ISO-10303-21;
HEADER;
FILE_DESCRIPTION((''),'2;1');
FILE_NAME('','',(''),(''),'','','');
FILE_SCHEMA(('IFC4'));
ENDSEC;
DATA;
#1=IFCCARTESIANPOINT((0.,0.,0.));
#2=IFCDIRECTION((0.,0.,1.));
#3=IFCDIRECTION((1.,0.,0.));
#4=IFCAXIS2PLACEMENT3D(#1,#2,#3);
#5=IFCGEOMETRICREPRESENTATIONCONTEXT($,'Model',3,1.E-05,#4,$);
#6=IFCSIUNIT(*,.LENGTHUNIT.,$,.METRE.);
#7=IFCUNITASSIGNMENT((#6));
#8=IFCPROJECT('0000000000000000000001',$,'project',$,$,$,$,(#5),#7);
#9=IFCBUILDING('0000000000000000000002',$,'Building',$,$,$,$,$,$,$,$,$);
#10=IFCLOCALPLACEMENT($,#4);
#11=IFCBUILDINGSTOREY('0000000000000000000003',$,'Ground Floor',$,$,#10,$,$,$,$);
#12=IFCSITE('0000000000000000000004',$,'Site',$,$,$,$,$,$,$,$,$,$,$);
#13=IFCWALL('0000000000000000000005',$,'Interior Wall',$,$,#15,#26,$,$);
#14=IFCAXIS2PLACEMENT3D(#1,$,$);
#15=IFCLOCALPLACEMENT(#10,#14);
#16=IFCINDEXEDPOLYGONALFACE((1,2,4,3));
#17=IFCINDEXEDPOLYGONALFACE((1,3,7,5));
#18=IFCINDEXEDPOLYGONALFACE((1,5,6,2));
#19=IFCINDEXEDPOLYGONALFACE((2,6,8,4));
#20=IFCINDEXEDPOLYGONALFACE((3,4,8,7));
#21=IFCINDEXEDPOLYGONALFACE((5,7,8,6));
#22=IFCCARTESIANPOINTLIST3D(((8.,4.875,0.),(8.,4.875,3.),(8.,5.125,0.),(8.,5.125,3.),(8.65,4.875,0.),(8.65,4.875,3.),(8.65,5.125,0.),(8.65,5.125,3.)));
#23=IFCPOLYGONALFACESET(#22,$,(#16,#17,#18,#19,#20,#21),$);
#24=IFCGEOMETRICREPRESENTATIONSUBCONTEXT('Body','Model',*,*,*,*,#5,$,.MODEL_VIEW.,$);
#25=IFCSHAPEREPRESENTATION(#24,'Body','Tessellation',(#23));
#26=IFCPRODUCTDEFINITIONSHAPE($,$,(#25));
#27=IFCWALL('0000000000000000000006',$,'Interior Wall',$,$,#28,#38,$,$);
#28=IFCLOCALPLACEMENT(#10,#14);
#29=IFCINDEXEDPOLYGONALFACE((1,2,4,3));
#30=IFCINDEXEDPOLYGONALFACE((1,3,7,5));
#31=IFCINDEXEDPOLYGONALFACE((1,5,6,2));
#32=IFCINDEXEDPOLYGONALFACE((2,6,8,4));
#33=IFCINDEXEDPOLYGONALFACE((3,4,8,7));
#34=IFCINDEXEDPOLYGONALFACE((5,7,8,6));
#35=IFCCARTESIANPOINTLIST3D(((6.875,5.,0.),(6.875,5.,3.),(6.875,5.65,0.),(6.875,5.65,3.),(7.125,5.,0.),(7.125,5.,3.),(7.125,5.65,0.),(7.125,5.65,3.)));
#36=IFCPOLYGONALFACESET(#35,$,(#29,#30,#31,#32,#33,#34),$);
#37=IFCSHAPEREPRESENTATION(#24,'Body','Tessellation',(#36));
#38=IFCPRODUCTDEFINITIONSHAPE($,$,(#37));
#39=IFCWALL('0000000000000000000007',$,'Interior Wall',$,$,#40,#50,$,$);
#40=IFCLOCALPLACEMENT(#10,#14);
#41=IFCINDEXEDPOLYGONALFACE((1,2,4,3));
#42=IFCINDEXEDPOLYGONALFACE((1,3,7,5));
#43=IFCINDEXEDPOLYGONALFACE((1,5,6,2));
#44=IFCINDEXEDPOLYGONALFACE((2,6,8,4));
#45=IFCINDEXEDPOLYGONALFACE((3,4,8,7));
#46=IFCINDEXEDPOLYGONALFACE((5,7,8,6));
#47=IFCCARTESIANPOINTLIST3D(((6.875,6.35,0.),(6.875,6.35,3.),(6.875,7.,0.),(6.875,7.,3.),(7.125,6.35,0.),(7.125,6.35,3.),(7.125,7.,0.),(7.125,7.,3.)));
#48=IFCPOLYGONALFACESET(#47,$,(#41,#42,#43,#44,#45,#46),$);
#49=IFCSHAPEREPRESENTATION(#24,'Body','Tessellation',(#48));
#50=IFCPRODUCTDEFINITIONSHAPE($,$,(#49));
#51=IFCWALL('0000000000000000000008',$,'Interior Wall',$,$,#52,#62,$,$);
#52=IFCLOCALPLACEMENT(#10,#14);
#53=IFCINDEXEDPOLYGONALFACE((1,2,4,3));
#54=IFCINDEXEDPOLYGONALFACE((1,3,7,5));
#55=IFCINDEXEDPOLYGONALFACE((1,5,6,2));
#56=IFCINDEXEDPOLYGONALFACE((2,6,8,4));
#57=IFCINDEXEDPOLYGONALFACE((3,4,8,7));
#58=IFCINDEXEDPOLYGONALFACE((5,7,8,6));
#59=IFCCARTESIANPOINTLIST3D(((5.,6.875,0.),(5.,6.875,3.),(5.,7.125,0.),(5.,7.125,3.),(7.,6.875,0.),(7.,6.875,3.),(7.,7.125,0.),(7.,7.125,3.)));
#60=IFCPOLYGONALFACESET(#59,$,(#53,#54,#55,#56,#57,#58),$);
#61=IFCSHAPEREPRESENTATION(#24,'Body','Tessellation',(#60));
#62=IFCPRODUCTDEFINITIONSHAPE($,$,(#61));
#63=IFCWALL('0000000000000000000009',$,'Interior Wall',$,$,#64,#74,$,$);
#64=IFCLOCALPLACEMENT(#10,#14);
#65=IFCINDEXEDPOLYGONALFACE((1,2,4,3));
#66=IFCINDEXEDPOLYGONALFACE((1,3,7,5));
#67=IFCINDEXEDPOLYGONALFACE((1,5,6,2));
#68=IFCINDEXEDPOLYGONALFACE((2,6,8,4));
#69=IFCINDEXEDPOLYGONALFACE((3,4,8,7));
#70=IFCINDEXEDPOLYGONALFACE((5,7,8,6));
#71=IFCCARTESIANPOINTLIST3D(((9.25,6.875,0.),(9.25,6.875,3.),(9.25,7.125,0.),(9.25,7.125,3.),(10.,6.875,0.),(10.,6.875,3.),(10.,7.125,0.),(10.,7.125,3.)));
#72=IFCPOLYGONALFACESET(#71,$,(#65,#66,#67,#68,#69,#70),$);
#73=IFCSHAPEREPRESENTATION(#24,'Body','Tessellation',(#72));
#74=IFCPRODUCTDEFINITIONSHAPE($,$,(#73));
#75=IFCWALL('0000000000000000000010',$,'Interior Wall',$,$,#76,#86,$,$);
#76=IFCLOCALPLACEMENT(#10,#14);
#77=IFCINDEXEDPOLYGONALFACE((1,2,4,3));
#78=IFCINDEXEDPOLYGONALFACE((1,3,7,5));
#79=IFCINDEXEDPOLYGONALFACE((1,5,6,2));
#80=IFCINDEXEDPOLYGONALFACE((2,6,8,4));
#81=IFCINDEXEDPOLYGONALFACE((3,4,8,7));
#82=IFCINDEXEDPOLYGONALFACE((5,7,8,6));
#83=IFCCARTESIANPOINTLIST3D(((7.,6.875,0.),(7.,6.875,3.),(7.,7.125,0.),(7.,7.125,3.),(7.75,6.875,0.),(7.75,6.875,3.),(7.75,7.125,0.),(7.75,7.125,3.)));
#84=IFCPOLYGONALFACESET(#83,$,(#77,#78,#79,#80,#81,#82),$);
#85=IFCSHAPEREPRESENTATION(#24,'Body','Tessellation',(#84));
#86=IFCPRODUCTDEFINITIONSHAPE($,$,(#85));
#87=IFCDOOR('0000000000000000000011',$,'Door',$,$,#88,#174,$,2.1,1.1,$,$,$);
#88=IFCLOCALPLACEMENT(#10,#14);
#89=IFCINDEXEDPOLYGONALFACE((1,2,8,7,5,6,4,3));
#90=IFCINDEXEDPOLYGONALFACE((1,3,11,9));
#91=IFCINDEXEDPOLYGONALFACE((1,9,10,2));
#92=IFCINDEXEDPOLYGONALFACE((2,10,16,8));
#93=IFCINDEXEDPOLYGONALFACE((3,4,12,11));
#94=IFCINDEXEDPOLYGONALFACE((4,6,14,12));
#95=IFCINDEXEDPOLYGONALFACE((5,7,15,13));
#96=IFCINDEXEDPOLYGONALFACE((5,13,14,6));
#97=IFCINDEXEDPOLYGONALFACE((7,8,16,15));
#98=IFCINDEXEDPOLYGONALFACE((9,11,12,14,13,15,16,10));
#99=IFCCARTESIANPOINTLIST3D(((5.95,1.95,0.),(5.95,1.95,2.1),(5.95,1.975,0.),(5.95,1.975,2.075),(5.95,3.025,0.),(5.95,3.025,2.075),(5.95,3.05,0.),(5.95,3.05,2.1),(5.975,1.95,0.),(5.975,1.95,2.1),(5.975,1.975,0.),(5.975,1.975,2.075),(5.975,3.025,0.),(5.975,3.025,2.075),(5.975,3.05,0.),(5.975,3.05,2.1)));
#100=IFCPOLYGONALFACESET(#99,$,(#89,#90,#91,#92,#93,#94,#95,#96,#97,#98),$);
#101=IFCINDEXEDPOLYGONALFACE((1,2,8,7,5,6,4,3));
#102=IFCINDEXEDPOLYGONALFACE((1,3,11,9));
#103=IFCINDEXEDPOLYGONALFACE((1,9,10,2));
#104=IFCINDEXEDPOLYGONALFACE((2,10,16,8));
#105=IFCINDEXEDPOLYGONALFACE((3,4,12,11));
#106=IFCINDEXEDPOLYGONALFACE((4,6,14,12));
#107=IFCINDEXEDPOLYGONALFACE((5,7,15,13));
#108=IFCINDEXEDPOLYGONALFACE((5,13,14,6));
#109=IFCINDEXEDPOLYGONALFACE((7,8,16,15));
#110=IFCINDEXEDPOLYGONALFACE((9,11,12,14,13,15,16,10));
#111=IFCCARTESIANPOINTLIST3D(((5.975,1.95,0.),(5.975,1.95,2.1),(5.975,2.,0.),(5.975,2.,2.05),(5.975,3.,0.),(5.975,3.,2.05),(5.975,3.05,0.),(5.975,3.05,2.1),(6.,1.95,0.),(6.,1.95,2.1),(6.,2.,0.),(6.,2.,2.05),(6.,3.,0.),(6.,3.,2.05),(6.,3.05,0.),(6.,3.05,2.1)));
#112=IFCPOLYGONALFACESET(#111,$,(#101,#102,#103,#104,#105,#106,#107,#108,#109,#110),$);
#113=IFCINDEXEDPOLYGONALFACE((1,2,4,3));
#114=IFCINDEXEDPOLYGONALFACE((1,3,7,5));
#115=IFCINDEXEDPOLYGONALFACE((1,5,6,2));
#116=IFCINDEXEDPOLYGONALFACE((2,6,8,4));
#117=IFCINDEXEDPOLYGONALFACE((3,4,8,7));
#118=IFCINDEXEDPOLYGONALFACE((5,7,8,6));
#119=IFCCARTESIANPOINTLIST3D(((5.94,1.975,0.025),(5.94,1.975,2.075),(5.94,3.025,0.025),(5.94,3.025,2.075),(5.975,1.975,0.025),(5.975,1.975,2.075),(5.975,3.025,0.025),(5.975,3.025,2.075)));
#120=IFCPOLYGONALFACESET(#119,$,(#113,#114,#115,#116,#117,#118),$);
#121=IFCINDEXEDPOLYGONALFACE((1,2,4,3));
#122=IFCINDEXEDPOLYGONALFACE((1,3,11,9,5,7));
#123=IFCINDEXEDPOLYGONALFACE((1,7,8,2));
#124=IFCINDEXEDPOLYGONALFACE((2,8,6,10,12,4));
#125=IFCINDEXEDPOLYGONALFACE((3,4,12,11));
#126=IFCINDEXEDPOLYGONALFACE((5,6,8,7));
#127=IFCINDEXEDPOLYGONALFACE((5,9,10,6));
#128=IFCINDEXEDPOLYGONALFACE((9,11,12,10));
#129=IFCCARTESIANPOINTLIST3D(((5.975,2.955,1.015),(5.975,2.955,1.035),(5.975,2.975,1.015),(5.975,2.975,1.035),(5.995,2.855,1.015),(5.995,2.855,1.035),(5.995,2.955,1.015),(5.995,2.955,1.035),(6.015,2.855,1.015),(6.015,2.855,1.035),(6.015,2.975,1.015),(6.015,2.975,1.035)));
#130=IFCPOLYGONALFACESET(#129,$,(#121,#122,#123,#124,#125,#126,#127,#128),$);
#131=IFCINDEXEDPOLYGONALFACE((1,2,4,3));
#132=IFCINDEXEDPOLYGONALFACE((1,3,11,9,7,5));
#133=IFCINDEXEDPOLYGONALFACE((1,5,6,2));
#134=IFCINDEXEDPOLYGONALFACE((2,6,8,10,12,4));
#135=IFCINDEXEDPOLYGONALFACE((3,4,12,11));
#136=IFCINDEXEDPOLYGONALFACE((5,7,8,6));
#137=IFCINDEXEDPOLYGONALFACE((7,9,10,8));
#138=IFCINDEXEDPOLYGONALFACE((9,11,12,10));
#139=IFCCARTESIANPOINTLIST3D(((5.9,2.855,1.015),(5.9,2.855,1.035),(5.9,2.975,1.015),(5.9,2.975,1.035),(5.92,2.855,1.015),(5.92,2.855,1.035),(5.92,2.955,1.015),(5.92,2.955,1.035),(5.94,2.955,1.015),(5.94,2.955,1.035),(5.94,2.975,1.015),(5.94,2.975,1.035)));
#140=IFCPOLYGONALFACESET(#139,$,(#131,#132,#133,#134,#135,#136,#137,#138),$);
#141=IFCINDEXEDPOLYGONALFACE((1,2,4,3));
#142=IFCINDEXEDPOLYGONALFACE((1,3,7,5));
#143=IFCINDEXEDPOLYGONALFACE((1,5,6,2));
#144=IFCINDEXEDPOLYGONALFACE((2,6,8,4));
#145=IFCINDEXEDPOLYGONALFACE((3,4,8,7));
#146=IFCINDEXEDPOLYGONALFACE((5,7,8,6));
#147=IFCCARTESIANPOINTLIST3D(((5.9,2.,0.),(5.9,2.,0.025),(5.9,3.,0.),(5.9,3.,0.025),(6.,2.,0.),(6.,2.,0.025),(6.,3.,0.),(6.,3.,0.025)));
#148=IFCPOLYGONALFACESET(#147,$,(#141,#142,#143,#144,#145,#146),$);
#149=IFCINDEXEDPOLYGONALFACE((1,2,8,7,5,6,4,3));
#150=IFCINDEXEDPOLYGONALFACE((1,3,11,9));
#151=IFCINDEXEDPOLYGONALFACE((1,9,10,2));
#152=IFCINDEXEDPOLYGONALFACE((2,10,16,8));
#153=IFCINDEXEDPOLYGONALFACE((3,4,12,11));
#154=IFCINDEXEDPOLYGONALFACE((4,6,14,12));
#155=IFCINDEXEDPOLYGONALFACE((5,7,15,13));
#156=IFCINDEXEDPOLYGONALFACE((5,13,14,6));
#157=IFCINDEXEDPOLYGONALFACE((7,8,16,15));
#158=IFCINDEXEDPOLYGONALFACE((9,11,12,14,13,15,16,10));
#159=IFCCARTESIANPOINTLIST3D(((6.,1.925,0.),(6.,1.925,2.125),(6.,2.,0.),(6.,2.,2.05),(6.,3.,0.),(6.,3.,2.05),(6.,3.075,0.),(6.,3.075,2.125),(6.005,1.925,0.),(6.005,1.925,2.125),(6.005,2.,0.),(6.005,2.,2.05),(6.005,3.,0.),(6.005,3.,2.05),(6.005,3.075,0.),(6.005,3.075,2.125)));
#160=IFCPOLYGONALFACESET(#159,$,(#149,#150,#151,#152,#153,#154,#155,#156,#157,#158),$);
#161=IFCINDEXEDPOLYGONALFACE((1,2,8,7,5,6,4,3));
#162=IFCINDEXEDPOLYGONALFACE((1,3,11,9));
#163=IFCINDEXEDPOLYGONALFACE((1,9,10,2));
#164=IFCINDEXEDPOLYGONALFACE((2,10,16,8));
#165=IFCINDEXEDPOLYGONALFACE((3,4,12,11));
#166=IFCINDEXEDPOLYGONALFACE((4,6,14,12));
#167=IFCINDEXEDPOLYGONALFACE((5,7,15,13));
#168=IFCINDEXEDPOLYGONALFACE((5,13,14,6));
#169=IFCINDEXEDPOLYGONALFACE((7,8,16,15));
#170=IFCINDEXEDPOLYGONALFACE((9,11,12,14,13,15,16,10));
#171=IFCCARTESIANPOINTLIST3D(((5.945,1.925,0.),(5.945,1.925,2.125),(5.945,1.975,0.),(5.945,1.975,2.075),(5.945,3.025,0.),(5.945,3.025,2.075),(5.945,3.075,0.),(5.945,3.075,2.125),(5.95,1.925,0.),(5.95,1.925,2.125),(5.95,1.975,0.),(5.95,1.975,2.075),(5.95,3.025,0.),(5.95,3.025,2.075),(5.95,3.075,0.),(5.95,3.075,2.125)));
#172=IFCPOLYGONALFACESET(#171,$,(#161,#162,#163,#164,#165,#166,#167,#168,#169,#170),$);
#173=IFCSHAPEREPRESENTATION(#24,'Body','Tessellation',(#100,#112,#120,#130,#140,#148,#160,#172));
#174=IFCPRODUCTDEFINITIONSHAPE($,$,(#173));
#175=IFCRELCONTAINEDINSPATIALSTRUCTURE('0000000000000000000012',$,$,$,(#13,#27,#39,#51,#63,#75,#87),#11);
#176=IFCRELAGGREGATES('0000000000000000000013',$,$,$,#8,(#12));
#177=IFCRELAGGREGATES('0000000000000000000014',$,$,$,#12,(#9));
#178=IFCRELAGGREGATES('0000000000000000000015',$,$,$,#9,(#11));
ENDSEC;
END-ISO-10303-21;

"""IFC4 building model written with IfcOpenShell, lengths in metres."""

from ifc_helpers import new_model, si_unit, frame, origin_with_axes, place, context, subcontext, project, spatial, line, indexed_curve, outline, extrude, element, save


model = new_model("IFC4")

# Units and contexts
model_context = context("Model", 3, precision=1e-05, world=origin_with_axes())
body_context = subcontext(model_context, "Body", "Model", "MODEL_VIEW")
ifc_project = project(units=[si_unit("LENGTHUNIT", "METRE")], contexts=[model_context])

# Site, building, storey
site = spatial("IfcSite", under=ifc_project, Name="Site")
building = spatial("IfcBuilding", under=site, Name="Building")
storey_placement = place(None, origin_with_axes())
storey = spatial("IfcBuildingStorey", under=building, at=storey_placement, Name="Ground Floor")

# Walls
for number, where, z_axis, x_axis, name in (
    (1, (8.65, 5.0, 0.0), (0.0, 0.0, 1.0), (-1.0, 0.0, 0.0), "Interior Wall"),
    (2, (7.0, 5.0, 0.0), (0.0, 0.0, 1.0), (0.0, 1.0, 0.0), "Interior Wall"),
    (3, (7.0, 6.35, 0.0), (0.0, 0.0, 1.0), (0.0, 1.0, 0.0), "Interior Wall"),
):
    element("IfcWall", number, at=place(storey_placement, frame(where, z_axis=z_axis, x_axis=x_axis)), inside=storey, Name=name, context=body_context, shape_type="SweptSolid", body=[
        extrude(outline(indexed_curve([(0.0, 0.0), (0.0, 0.25), (0.65, 0.25), (0.65, 0.0), (0.0, 0.0)], self_intersect=False)), frame((0.0, -0.125, 0.0), z_axis=(0.0, 0.0, 1.0), x_axis=(1.0, 0.0, 0.0)), (0.0, 0.0, 1.0), 3.0),
    ])
wall_1_placement = place(storey_placement, frame((7.0, 7.0, 0.0), z_axis=(0.0, 0.0, 1.0), x_axis=(-1.0, 0.0, 0.0)))
element("IfcWall", 4, at=wall_1_placement, inside=storey, Name="Interior Wall", context=body_context, shape_type="SweptSolid", body=[
    extrude(outline(indexed_curve([(0.0, 0.0), (0.0, 0.25), (2.0, 0.25), (2.0, 0.0), (0.0, 0.0)], self_intersect=False)), frame((0.0, -0.125, 0.0), z_axis=(0.0, 0.0, 1.0), x_axis=(1.0, 0.0, 0.0)), (0.0, 0.0, 1.0), 3.0),
])
for number, where, z_axis, x_axis, name in (
    (5, (10.0, 7.0, 0.0), (0.0, 0.0, 1.0), (-1.0, 0.0, 0.0), "Interior Wall"),
    (6, (7.75, 7.0, 0.0), (0.0, 0.0, 1.0), (-1.0, 0.0, 0.0), "Interior Wall"),
):
    element("IfcWall", number, at=place(storey_placement, frame(where, z_axis=z_axis, x_axis=x_axis)), inside=storey, Name=name, context=body_context, shape_type="SweptSolid", body=[
        extrude(outline(indexed_curve([(0.0, 0.0), (0.0, 0.25), (0.75, 0.25), (0.75, 0.0), (0.0, 0.0)], self_intersect=False)), frame((0.0, -0.125, 0.0), z_axis=(0.0, 0.0, 1.0), x_axis=(1.0, 0.0, 0.0)), (0.0, 0.0, 1.0), 3.0),
    ])

# Door
door_1_placement = place(storey_placement, frame((6.0, 1.95, 0.0), z_axis=(0.0, 0.0, 1.0), x_axis=(0.0, 1.0, 0.0)))
element("IfcDoor", 7, at=door_1_placement, inside=storey, Name="Door", OverallHeight=2.1, OverallWidth=1.1, context=body_context, shape_type="SweptSolid", body=[
    extrude(outline(indexed_curve([(0.0, 0.0), (0.0, 2.1), (1.1, 2.1), (1.1, 0.0), (1.075, 0.0), (1.075, 2.075), (0.025, 2.075), (0.025, 0.0)], segments=[line(1, 2, 3, 4, 5, 6, 7, 8, 1)])), frame((0.0, 0.025, 0.0), z_axis=(0.0, -1.0, 0.0), x_axis=(1.0, 0.0, 0.0)), (0.0, 0.0, -1.0), 0.025),
    extrude(outline(indexed_curve([(0.0, 0.0), (0.0, 2.1), (1.1, 2.1), (1.1, 0.0), (1.05, 0.0), (1.05, 2.05), (0.05, 2.05), (0.05, 0.0)], segments=[line(1, 2, 3, 4, 5, 6, 7, 8, 1)])), frame((0.0, 0.0, 0.0), z_axis=(0.0, -1.0, 0.0), x_axis=(1.0, 0.0, 0.0)), (0.0, 0.0, -1.0), 0.025),
    extrude(outline(indexed_curve([(0.0, 0.0), (1.05, 0.0), (1.05, 0.035), (0.0, 0.035)], segments=[line(1, 2, 3, 4, 1)])), frame((0.025, 0.025, 0.025), z_axis=(0.0, 0.0, 1.0), x_axis=(1.0, 0.0, 0.0)), (0.0, 0.0, 1.0), 2.05),
    extrude(outline(indexed_curve([(0.0, 0.0), (0.0, -0.04), (-0.12, -0.04), (-0.12, -0.02), (-0.02, -0.02), (-0.02, 0.0)], segments=[line(1, 2, 3, 4, 5, 6, 1)])), frame((1.025, 0.025, 1.015), z_axis=(0.0, 0.0, 1.0), x_axis=(1.0, 0.0, 0.0)), (0.0, 0.0, 1.0), 0.02),
    extrude(outline(indexed_curve([(0.0, 0.0), (0.0, 0.04), (-0.12, 0.04), (-0.12, 0.02), (-0.02, 0.02), (-0.02, 0.0)], segments=[line(1, 2, 3, 4, 5, 6, 1)])), frame((1.025, 0.06, 1.015), z_axis=(0.0, 0.0, 1.0), x_axis=(1.0, 0.0, 0.0)), (0.0, 0.0, 1.0), 0.02),
    extrude(outline(indexed_curve([(0.0, 0.0), (1.0, 0.0), (1.0, 0.1), (0.0, 0.1)], segments=[line(1, 2, 3, 4, 1)])), frame((0.05, 0.0, 0.0), z_axis=(0.0, 0.0, 1.0), x_axis=(1.0, 0.0, 0.0)), (0.0, 0.0, 1.0), 0.025),
    extrude(outline(indexed_curve([(0.0, 0.0), (0.0, 2.125), (1.15, 2.125), (1.15, 0.0), (1.075, 0.0), (1.075, 2.05), (0.075, 2.05), (0.075, 0.0)], segments=[line(1, 2, 3, 4, 5, 6, 7, 8, 1)])), frame((-0.025, -0.005, 0.0), z_axis=(0.0, -1.0, 0.0), x_axis=(1.0, 0.0, 0.0)), (0.0, 0.0, -1.0), 0.005),
    extrude(outline(indexed_curve([(0.0, 0.0), (0.0, 2.125), (1.15, 2.125), (1.15, 0.0), (1.1, 0.0), (1.1, 2.075), (0.05, 2.075), (0.05, 0.0)], segments=[line(1, 2, 3, 4, 5, 6, 7, 8, 1)])), frame((-0.025, 0.05, 0.0), z_axis=(0.0, -1.0, 0.0), x_axis=(1.0, 0.0, 0.0)), (0.0, 0.0, -1.0), 0.005),
])

save(model, "model.ifc")
